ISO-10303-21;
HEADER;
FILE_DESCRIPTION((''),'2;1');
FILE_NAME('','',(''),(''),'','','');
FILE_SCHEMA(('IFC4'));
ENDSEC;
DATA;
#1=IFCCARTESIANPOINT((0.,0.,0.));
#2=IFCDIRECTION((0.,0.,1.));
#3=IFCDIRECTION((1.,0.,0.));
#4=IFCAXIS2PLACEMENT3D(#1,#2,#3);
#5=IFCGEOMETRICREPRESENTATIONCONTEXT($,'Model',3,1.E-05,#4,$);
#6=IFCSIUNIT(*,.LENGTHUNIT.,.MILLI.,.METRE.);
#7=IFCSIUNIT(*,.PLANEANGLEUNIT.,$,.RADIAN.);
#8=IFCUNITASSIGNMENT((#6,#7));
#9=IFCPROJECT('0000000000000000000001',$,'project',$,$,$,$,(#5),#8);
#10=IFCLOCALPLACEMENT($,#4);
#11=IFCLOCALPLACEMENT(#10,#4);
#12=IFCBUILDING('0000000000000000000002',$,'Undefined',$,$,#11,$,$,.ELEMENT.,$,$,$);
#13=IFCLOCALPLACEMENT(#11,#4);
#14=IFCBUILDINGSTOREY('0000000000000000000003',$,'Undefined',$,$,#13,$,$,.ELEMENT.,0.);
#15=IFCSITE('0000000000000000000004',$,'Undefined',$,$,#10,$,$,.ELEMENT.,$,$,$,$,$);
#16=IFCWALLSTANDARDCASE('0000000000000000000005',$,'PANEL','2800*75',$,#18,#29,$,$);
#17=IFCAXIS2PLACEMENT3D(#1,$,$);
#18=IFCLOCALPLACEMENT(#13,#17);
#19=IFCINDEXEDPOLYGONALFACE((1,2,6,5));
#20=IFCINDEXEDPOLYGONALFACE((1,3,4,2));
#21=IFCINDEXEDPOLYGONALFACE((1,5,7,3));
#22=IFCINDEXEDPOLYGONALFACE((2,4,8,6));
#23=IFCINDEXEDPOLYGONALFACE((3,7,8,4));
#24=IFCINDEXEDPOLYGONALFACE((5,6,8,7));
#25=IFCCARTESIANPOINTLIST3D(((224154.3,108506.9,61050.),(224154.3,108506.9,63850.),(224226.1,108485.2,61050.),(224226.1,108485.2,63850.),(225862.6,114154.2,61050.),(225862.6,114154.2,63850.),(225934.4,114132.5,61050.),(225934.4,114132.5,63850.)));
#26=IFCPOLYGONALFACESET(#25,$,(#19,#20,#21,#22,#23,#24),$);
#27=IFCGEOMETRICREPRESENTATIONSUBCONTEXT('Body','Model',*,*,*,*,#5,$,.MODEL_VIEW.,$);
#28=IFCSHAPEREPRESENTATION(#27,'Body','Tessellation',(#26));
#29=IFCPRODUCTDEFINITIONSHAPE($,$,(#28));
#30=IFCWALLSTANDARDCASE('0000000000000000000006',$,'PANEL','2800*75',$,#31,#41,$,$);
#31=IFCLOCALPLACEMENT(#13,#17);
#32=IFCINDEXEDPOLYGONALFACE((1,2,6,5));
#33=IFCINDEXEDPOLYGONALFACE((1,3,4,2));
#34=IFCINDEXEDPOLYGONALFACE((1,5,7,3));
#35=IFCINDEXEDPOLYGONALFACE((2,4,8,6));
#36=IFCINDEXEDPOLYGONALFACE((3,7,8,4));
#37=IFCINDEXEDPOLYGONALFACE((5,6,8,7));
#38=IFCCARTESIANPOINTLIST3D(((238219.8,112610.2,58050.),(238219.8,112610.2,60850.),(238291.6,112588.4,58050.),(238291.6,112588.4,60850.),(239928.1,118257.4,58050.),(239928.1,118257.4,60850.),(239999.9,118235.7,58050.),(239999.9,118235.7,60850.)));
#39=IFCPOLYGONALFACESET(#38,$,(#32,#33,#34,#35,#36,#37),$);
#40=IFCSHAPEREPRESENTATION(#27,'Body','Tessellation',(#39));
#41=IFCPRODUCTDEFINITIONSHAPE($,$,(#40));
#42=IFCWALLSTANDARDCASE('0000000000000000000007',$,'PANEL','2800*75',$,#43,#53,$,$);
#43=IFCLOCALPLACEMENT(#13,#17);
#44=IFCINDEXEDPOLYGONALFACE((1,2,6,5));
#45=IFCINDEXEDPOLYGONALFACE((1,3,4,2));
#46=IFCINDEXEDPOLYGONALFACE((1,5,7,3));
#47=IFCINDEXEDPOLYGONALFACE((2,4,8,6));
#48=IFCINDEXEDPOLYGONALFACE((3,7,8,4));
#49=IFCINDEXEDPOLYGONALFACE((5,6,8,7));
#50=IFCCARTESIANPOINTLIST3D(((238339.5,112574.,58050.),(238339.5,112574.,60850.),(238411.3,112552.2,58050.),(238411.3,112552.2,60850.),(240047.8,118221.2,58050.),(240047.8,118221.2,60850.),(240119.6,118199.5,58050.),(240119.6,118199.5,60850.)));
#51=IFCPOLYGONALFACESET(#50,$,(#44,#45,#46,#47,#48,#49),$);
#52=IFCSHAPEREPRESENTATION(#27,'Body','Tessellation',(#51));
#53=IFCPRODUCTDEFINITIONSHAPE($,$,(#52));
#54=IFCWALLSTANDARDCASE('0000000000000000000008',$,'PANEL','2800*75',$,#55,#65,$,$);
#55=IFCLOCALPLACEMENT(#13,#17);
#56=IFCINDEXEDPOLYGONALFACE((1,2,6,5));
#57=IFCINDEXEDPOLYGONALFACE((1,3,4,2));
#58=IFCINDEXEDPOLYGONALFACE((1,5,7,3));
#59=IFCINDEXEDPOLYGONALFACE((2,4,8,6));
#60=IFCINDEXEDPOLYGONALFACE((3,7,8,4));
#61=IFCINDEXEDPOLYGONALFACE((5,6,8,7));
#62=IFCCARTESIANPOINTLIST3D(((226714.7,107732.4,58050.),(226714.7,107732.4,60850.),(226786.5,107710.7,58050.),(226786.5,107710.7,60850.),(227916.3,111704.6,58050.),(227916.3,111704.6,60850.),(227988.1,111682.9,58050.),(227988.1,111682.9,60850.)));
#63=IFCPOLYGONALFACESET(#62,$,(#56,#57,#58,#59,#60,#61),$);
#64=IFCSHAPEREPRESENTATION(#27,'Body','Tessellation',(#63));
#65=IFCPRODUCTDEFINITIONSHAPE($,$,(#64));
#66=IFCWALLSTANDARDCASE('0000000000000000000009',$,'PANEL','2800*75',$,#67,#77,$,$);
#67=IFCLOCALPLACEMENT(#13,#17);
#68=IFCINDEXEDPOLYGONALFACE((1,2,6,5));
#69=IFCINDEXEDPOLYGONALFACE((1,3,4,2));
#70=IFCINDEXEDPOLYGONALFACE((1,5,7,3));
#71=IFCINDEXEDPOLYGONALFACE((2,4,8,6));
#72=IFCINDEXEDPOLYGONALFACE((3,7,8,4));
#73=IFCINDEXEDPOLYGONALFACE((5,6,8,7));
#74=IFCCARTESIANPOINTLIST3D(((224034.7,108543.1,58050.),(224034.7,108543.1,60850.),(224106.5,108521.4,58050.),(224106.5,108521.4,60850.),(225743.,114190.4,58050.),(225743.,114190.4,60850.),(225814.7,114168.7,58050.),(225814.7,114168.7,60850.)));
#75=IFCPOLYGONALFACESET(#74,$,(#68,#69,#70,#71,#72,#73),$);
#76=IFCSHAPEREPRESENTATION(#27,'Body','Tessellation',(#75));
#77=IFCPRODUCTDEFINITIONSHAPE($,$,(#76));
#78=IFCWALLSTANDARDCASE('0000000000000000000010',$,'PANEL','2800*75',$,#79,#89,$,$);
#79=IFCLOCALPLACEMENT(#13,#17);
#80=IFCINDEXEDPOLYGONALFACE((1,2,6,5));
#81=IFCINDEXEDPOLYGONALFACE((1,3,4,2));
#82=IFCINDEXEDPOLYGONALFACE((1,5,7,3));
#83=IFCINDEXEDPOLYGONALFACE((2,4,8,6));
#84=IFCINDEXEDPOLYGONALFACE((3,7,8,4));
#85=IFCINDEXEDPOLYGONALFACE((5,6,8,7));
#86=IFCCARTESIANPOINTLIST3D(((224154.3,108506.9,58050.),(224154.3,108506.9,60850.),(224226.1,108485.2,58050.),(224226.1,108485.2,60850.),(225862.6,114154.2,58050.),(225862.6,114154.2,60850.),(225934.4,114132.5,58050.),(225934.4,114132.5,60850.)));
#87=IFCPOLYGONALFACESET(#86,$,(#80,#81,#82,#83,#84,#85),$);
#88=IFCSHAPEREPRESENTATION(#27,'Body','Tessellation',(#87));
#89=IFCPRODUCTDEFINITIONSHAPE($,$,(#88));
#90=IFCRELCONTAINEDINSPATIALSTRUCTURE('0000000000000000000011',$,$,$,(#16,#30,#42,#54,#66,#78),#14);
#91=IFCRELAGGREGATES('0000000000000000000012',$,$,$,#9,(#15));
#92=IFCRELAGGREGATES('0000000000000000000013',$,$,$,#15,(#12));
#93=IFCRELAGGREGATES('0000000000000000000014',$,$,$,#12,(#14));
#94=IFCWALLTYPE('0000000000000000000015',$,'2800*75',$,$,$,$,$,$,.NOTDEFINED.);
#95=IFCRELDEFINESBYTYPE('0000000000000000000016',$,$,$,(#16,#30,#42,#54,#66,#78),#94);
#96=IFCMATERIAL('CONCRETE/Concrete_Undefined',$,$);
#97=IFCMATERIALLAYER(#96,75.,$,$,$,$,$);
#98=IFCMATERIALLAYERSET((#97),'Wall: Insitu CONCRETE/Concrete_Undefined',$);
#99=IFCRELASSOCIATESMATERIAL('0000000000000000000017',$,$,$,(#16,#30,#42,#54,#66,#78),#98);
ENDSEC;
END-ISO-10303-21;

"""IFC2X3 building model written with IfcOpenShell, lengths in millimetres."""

from ifc_helpers import new_model, si_unit, frame, frame_2d, origin_with_axes, place, context, subcontext, project, spatial, rectangle, extrude, material, layer, layer_set, layer_usage, type_object, element, save


model = new_model("IFC2X3")

# Units and contexts
model_context = context("Model", 3, precision=1e-05, world=origin_with_axes())
body_context = subcontext(model_context, "Body", "Model", "MODEL_VIEW")
ifc_project = project(units=[si_unit("LENGTHUNIT", "METRE", prefix="MILLI"), si_unit("PLANEANGLEUNIT", "RADIAN")], contexts=[model_context])

# Site, building, storey
site_placement = place(None, origin_with_axes())
site = spatial("IfcSite", under=ifc_project, at=site_placement, Name="Undefined", CompositionType="ELEMENT")
building_placement = place(site_placement, origin_with_axes())
building = spatial("IfcBuilding", under=site, at=building_placement, Name="Undefined", CompositionType="ELEMENT")
storey_placement = place(building_placement, origin_with_axes())
storey = spatial("IfcBuildingStorey", under=building, at=storey_placement, Name="Undefined", CompositionType="ELEMENT", Elevation=0.0)

# Shared definitions
ifc_material_1 = material(Name="CONCRETE/Concrete_Undefined")

# Walls
ifc_layer_1 = layer(ifc_material_1, 75.0)
ifc_layer_set_1 = layer_set([ifc_layer_1], Name="Wall: Insitu CONCRETE/Concrete_Undefined")
wall_type_1 = type_object("IfcWallType", Name="2800*75", PredefinedType="NOTDEFINED")
ifc_layer_usage_1 = layer_usage(ifc_layer_set_1, "AXIS2", "POSITIVE", -37.5)
wall_1_placement = place(storey_placement, frame((224190.2, 108496.0, 61050.0), z_axis=(0.0, 0.0, 1.0), x_axis=(0.289538, 0.957166, 0.0)))
element("IfcWallStandardCase", 1, at=wall_1_placement, inside=storey, type_object=wall_type_1, material=ifc_layer_usage_1, Name="PANEL", Description="2800*75", context=body_context, shape_type="SweptSolid", body=[
    extrude(rectangle(XDim=5900.0, YDim=75.0, at=frame_2d((0.0, 2950.0), x_axis=(0.0, -1.0))), frame((0.0, 0.0, 0.0), z_axis=(0.0, 0.0, 1.0), x_axis=(0.0, -1.0, 0.0)), (0.0, 0.0, 1.0), 2800.0),
])
ifc_layer_usage_2 = layer_usage(ifc_layer_set_1, "AXIS2", "POSITIVE", -37.5)
wall_2_placement = place(storey_placement, frame((238255.7, 112599.3, 58050.0), z_axis=(0.0, 0.0, 1.0), x_axis=(0.289537, 0.957167, 0.0)))
element("IfcWallStandardCase", 2, at=wall_2_placement, inside=storey, type_object=wall_type_1, material=ifc_layer_usage_2, Name="PANEL", Description="2800*75", context=body_context, shape_type="SweptSolid", body=[
    extrude(rectangle(XDim=5900.0, YDim=75.0, at=frame_2d((0.0, 2950.0), x_axis=(0.0, -1.0))), frame((0.0, 0.0, 0.0), z_axis=(0.0, 0.0, 1.0), x_axis=(0.0, -1.0, 0.0)), (0.0, 0.0, 1.0), 2800.0),
])
ifc_layer_usage_3 = layer_usage(ifc_layer_set_1, "AXIS2", "POSITIVE", -37.5)
wall_3_placement = place(storey_placement, frame((238375.4, 112563.1, 58050.0), z_axis=(0.0, 0.0, 1.0), x_axis=(0.289537, 0.957167, 0.0)))
element("IfcWallStandardCase", 3, at=wall_3_placement, inside=storey, type_object=wall_type_1, material=ifc_layer_usage_3, Name="PANEL", Description="2800*75", context=body_context, shape_type="SweptSolid", body=[
    extrude(rectangle(XDim=5900.0, YDim=75.0, at=frame_2d((0.0, 2950.0), x_axis=(0.0, -1.0))), frame((0.0, 0.0, 0.0), z_axis=(0.0, 0.0, 1.0), x_axis=(0.0, -1.0, 0.0)), (0.0, 0.0, 1.0), 2800.0),
])
ifc_layer_usage_4 = layer_usage(ifc_layer_set_1, "AXIS2", "POSITIVE", -37.5)
wall_4_placement = place(storey_placement, frame((226750.6, 107721.5, 58050.0), z_axis=(0.0, 0.0, 1.0), x_axis=(0.289539, 0.957166, 0.0)))
element("IfcWallStandardCase", 4, at=wall_4_placement, inside=storey, type_object=wall_type_1, material=ifc_layer_usage_4, Name="PANEL", Description="2800*75", context=body_context, shape_type="SweptSolid", body=[
    extrude(rectangle(XDim=4150.0, YDim=75.0, at=frame_2d((0.0, 2075.0), x_axis=(0.0, -1.0))), frame((0.0, 0.0, 0.0), z_axis=(0.0, 0.0, 1.0), x_axis=(0.0, -1.0, 0.0)), (0.0, 0.0, 1.0), 2800.0),
])
ifc_layer_usage_5 = layer_usage(ifc_layer_set_1, "AXIS2", "POSITIVE", -37.5)
wall_5_placement = place(storey_placement, frame((224070.6, 108532.2, 58050.0), z_axis=(0.0, 0.0, 1.0), x_axis=(0.289538, 0.957166, 0.0)))
element("IfcWallStandardCase", 5, at=wall_5_placement, inside=storey, type_object=wall_type_1, material=ifc_layer_usage_5, Name="PANEL", Description="2800*75", context=body_context, shape_type="SweptSolid", body=[
    extrude(rectangle(XDim=5900.0, YDim=75.0, at=frame_2d((0.0, 2950.0), x_axis=(0.0, -1.0))), frame((0.0, 0.0, 0.0), z_axis=(0.0, 0.0, 1.0), x_axis=(0.0, -1.0, 0.0)), (0.0, 0.0, 1.0), 2800.0),
])
ifc_layer_usage_6 = layer_usage(ifc_layer_set_1, "AXIS2", "POSITIVE", -37.5)
wall_6_placement = place(storey_placement, frame((224190.2, 108496.0, 58050.0), z_axis=(0.0, 0.0, 1.0), x_axis=(0.289538, 0.957166, 0.0)))
element("IfcWallStandardCase", 6, at=wall_6_placement, inside=storey, type_object=wall_type_1, material=ifc_layer_usage_6, Name="PANEL", Description="2800*75", context=body_context, shape_type="SweptSolid", body=[
    extrude(rectangle(XDim=5900.0, YDim=75.0, at=frame_2d((0.0, 2950.0), x_axis=(0.0, -1.0))), frame((0.0, 0.0, 0.0), z_axis=(0.0, 0.0, 1.0), x_axis=(0.0, -1.0, 0.0)), (0.0, 0.0, 1.0), 2800.0),
])

save(model, "model.ifc")
